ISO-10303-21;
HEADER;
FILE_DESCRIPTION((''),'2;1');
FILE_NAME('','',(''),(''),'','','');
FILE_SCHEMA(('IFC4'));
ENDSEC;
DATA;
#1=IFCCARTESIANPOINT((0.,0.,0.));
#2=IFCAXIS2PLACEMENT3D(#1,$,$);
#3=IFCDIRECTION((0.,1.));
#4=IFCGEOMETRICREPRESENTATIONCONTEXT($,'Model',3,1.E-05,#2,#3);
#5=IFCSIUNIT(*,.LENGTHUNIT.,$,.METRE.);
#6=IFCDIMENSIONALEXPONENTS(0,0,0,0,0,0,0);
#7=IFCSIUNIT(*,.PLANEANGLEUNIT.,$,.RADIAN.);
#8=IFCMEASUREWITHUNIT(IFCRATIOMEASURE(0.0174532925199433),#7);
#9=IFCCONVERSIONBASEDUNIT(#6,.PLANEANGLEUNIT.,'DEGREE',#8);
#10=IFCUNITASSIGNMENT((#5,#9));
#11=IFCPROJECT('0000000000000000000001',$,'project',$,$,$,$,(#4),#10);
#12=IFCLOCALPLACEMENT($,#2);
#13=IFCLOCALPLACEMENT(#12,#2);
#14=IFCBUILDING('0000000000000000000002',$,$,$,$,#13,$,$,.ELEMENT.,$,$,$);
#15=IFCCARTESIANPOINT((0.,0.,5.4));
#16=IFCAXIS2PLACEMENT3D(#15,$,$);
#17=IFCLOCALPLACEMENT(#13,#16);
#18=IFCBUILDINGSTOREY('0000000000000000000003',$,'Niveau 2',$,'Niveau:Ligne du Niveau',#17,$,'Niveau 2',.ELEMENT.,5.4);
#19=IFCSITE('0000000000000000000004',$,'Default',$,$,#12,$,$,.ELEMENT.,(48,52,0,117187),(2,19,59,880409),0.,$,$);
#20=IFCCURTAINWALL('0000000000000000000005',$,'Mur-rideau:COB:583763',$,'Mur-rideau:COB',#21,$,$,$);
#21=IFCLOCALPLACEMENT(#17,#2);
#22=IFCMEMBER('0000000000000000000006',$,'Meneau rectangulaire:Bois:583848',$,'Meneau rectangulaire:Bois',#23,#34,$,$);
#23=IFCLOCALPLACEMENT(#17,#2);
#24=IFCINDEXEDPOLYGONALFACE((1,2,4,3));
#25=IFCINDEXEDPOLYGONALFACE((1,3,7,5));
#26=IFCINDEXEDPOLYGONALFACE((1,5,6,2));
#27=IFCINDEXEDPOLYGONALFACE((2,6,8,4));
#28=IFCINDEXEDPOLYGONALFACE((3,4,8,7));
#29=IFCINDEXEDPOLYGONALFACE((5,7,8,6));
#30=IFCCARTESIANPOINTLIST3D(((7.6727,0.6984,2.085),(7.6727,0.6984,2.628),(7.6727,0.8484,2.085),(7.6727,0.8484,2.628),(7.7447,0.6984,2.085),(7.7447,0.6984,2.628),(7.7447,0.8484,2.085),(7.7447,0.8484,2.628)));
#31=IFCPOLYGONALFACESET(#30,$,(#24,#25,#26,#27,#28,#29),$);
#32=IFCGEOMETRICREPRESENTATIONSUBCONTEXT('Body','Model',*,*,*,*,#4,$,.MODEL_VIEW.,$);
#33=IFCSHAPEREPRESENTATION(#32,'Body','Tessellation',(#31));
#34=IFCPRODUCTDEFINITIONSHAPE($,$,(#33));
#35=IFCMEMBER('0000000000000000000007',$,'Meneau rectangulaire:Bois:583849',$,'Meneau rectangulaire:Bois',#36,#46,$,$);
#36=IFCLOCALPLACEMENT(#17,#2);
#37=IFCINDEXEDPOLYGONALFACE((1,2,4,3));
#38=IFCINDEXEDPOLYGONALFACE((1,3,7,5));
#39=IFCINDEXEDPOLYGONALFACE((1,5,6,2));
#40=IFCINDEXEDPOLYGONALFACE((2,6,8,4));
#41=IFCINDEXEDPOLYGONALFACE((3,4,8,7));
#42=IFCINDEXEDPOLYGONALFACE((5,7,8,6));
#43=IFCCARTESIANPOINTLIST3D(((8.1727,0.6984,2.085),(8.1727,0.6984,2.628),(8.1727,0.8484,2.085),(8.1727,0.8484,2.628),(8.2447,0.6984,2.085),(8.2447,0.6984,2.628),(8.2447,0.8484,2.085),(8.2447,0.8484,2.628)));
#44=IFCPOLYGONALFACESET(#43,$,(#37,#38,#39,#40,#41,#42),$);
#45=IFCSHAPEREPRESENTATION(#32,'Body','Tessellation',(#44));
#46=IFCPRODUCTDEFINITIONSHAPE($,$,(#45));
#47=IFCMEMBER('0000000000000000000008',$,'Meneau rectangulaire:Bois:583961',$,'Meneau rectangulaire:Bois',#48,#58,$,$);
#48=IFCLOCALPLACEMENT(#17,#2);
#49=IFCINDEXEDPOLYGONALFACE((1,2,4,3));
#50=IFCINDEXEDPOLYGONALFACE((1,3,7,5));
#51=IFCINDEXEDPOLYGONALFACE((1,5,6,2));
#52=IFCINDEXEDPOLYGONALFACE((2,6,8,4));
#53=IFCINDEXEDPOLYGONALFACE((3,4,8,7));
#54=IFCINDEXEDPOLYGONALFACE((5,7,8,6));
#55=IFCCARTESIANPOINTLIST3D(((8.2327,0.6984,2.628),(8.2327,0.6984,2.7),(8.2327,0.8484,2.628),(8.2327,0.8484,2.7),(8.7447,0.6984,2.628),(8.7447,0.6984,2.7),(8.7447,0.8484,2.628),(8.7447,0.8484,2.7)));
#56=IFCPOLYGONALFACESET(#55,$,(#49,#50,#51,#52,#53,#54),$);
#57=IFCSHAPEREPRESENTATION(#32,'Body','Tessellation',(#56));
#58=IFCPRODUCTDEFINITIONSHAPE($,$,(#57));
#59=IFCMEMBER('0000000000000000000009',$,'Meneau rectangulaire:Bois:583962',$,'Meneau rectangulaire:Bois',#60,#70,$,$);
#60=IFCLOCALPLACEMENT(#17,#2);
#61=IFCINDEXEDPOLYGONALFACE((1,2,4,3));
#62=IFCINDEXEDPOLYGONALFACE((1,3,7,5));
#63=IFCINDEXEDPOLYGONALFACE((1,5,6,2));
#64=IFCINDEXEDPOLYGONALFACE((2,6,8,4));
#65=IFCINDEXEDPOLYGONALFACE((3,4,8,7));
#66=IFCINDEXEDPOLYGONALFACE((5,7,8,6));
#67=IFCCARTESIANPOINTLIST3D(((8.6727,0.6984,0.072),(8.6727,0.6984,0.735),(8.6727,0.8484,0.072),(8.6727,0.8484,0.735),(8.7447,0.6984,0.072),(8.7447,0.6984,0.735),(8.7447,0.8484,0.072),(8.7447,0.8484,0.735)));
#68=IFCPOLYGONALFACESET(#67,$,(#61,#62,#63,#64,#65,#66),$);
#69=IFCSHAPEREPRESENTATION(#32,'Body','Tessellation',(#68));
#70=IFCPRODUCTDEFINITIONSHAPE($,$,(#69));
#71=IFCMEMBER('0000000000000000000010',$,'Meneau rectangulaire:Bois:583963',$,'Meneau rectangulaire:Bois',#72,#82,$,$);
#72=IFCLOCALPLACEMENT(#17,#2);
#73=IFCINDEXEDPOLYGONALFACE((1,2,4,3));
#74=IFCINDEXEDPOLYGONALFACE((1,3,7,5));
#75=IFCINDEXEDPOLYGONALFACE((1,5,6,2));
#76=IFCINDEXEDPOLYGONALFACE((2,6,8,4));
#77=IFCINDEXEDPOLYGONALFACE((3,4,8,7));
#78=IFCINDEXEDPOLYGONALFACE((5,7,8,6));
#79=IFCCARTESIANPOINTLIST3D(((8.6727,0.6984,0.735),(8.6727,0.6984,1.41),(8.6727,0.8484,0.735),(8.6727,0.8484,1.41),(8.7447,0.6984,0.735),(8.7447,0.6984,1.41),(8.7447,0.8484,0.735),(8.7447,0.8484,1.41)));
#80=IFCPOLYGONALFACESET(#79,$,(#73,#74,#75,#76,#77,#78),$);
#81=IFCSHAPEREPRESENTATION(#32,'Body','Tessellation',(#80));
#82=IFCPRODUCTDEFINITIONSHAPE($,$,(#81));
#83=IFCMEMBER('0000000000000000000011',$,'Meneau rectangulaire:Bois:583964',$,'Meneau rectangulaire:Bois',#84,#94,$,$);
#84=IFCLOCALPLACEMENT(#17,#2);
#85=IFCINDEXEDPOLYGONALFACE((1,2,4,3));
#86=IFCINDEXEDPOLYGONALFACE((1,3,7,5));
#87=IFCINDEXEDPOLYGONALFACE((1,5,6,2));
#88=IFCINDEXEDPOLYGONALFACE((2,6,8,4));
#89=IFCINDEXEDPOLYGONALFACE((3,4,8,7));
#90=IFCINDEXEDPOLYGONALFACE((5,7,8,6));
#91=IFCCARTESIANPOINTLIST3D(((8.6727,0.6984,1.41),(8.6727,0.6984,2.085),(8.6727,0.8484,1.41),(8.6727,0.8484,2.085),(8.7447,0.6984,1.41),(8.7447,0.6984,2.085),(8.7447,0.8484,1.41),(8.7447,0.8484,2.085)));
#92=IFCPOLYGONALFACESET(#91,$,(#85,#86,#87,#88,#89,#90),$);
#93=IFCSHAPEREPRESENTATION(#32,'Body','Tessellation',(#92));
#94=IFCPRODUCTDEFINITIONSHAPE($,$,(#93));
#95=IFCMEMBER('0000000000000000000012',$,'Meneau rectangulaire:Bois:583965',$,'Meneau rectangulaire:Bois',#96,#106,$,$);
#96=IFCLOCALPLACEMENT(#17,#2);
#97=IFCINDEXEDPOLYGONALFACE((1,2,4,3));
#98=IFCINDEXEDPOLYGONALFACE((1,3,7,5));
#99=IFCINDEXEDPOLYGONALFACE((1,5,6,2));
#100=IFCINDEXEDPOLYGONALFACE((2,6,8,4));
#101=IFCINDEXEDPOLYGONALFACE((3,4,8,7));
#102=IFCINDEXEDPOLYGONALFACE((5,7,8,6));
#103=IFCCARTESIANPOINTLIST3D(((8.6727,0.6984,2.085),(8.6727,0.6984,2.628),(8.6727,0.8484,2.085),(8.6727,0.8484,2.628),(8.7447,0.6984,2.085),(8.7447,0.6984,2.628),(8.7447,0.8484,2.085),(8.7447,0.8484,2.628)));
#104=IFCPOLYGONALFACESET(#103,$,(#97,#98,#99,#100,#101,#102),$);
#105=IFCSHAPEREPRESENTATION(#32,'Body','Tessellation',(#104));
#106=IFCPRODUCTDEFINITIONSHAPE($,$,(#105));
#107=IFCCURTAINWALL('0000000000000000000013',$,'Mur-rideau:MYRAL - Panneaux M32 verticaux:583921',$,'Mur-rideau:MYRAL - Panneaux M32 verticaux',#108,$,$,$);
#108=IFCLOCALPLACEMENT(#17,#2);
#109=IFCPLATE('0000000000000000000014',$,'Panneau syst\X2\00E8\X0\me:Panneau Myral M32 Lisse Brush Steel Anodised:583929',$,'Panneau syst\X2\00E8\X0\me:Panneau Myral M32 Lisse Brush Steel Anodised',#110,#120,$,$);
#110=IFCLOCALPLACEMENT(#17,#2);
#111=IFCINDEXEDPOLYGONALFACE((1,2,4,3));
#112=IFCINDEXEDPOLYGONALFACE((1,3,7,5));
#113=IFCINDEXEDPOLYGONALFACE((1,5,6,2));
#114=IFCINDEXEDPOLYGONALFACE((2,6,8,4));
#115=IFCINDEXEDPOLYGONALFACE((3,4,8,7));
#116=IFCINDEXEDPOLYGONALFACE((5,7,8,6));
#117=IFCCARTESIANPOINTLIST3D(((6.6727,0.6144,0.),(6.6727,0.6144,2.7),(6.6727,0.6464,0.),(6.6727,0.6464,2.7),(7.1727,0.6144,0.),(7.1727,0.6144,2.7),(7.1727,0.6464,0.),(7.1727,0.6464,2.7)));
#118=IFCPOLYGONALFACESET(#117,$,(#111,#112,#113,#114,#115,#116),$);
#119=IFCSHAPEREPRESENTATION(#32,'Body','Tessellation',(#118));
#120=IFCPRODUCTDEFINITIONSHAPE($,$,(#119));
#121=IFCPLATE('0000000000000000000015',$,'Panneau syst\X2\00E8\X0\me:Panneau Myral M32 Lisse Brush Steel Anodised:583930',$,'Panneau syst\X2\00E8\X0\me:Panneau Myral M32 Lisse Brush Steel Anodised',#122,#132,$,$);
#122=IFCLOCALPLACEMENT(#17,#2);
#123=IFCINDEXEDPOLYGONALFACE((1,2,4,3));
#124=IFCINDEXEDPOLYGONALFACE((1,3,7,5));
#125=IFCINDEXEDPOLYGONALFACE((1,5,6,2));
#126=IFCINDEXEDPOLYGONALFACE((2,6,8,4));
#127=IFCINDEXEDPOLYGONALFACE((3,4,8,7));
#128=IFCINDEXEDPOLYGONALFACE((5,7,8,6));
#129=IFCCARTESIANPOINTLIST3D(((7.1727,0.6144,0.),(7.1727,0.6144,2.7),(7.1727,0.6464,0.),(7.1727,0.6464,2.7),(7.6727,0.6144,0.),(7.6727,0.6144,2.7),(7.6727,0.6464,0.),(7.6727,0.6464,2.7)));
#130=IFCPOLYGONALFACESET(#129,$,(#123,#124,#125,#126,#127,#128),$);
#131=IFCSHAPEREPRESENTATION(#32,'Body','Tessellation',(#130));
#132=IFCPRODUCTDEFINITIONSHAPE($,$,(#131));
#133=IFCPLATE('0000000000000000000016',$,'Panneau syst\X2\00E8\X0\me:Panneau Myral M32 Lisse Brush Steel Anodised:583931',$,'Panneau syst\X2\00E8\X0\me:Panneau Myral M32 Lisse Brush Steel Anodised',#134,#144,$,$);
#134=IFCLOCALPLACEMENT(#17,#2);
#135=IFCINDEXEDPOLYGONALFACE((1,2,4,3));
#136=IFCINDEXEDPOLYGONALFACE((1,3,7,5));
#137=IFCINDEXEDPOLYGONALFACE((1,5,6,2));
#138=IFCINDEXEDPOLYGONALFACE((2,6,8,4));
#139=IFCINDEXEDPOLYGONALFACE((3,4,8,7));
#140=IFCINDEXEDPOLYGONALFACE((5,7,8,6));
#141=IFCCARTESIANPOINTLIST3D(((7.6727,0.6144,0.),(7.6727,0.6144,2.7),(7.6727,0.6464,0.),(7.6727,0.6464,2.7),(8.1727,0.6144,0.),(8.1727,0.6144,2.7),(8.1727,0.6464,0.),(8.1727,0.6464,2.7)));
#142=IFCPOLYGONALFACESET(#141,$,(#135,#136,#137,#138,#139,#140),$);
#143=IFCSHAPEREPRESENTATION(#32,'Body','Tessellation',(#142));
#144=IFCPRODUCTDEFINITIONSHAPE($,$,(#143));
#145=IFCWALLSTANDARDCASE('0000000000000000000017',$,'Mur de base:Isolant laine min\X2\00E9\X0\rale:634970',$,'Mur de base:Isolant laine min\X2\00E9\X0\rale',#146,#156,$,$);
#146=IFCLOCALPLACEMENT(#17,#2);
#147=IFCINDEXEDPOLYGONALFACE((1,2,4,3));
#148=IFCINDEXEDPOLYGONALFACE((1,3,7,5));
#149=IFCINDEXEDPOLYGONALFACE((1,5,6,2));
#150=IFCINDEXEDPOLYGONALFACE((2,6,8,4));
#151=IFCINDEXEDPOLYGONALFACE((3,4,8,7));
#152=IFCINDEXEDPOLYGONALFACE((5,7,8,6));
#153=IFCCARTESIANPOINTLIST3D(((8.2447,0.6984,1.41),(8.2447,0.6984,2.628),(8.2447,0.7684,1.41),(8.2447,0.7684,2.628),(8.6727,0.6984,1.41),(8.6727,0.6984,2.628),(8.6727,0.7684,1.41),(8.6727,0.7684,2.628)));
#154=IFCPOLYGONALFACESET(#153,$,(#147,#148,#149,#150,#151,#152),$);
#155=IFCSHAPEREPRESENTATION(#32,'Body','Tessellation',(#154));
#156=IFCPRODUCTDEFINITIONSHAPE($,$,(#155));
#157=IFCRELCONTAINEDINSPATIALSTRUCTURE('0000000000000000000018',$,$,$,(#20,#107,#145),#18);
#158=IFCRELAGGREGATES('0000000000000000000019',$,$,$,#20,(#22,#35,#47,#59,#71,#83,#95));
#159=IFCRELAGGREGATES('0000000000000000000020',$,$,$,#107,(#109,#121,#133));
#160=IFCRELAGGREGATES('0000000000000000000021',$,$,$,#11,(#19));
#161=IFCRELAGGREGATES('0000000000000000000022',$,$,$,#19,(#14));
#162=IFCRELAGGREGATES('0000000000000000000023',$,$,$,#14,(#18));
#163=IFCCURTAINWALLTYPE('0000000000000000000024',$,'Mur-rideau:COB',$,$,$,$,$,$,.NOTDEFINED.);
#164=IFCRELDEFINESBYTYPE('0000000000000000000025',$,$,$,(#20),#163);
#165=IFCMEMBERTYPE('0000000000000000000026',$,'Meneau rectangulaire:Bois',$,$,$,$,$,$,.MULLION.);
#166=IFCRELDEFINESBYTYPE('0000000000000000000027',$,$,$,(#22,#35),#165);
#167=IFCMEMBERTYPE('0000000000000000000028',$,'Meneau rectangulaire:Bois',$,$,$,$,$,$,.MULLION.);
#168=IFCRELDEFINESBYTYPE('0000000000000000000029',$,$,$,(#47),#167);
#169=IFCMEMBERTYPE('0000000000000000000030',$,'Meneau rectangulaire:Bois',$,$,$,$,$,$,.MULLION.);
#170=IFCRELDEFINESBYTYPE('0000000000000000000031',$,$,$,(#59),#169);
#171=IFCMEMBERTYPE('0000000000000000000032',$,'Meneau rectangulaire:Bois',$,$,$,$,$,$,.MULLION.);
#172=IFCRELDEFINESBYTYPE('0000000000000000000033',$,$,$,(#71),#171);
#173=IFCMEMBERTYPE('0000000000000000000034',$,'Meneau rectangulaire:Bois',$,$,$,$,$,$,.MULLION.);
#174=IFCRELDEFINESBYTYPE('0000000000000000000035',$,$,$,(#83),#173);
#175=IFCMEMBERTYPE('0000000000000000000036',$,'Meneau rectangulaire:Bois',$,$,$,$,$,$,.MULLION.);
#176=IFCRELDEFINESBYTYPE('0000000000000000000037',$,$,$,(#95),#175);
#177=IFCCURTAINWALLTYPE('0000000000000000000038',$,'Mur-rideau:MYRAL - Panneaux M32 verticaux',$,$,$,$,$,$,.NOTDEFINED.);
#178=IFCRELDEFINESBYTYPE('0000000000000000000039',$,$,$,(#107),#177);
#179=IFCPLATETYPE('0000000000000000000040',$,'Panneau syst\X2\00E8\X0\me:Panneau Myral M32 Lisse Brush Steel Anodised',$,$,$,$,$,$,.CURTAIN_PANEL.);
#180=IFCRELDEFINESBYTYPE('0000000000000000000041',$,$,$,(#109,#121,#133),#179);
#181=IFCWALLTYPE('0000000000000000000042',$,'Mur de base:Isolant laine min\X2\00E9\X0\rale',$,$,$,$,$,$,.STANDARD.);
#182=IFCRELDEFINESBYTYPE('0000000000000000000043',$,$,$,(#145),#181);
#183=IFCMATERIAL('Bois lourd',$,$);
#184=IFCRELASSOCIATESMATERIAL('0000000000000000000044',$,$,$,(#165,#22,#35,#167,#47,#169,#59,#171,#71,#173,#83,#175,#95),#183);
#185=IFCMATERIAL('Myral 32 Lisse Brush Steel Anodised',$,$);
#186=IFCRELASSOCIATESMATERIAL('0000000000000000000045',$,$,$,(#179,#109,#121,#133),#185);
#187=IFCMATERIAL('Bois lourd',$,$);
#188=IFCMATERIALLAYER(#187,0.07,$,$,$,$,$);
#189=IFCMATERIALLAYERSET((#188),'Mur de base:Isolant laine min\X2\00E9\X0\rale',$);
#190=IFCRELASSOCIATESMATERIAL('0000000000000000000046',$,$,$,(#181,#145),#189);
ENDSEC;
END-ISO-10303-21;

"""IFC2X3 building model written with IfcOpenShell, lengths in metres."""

from ifc_helpers import new_model, entity, si_unit, converted_unit, direction, frame, frame_2d, origin, origin_2d_with_axis, place, context, subcontext, project, spatial, rectangle, extrude, source, transform, mapped, material, layer, layer_set, layer_usage, type_object, type_shapes, element, aggregate, save


model = new_model("IFC2X3")

# Units and contexts
model_context = context("Model", 3, precision=1e-05, world=origin(), true_north=direction((0.0, 1.0)))
body_context = subcontext(model_context, "Body", "Model", "MODEL_VIEW")
ifc_project = project(units=[si_unit("LENGTHUNIT", "METRE"), converted_unit("PLANEANGLEUNIT", "DEGREE", entity("IfcRatioMeasure", 0.0174532925199433), si_unit("PLANEANGLEUNIT", "RADIAN"), dimensions=[0, 0, 0, 0, 0, 0, 0])], contexts=[model_context])

# Site, building, storey
site_placement = place(None, origin())
site = spatial("IfcSite", under=ifc_project, at=site_placement, Name="Default", CompositionType="ELEMENT", RefLatitude=(48, 52, 0, 117187), RefLongitude=(2, 19, 59, 880409), RefElevation=0.0)
building_placement = place(site_placement, origin())
building = spatial("IfcBuilding", under=site, at=building_placement, CompositionType="ELEMENT")
storey_placement = place(building_placement, frame((0.0, 0.0, 5.4)))
storey = spatial("IfcBuildingStorey", under=building, at=storey_placement, Name="Niveau 2", ObjectType="Niveau:Ligne du Niveau", LongName="Niveau 2", CompositionType="ELEMENT", Elevation=5.4)

# Curtain wall, members
curtain_wall_type_1 = type_object("IfcCurtainWallType", Name="Mur-rideau:COB", PredefinedType="NOTDEFINED")
curtain_wall_1_placement = place(storey_placement, frame((0.0, 0.0, -5.4)))
curtain_wall_1 = element("IfcCurtainWall", 1, at=curtain_wall_1_placement, inside=storey, type_object=curtain_wall_type_1, Name="Mur-rideau:COB:583763", ObjectType="Mur-rideau:COB")
ifc_material_1 = material(Name="Bois lourd")
member_type_1 = type_object("IfcMemberType", Name="Meneau rectangulaire:Bois", PredefinedType="MULLION", material=ifc_material_1)
shared_shape_1 = source(origin(), body_context, "Body", "SweptSolid", [
    extrude(rectangle(XDim=0.15, YDim=0.072, at=origin_2d_with_axis()), frame((-0.024, 0.0, -0.543), z_axis=(0.0, 0.0, 1.0), x_axis=(0.0, -1.0, 0.0)), (0.0, 0.0, 1.0), 0.543),
])
type_shapes(member_type_1, [shared_shape_1])
member_1_placement = place(storey_placement, frame((7.7327, 0.7734, 2.085), z_axis=(0.0, 0.0, -1.0), x_axis=(1.0, 0.0, 0.0)))
member_1 = element("IfcMember", 2, at=member_1_placement, type_object=member_type_1, material=ifc_material_1, Name="Meneau rectangulaire:Bois:583848", ObjectType="Meneau rectangulaire:Bois", context=body_context, shape_type="MappedRepresentation", body=[
    mapped(shared_shape_1, transform((0.0, 0.0, 0.0), scale=1.0)),
])
member_2_placement = place(storey_placement, frame((8.2327, 0.7734, 2.085), z_axis=(0.0, 0.0, -1.0), x_axis=(1.0, 0.0, 0.0)))
member_2 = element("IfcMember", 3, at=member_2_placement, type_object=member_type_1, material=ifc_material_1, Name="Meneau rectangulaire:Bois:583849", ObjectType="Meneau rectangulaire:Bois", context=body_context, shape_type="MappedRepresentation", body=[
    mapped(shared_shape_1, transform((0.0, 0.0, 0.0), scale=1.0)),
])
member_type_2 = type_object("IfcMemberType", Name="Meneau rectangulaire:Bois", PredefinedType="MULLION", material=ifc_material_1)
shared_shape_2 = source(origin(), body_context, "Body", "SweptSolid", [
    extrude(rectangle(XDim=0.15, YDim=0.072, at=origin_2d_with_axis()), frame((-0.036, 0.0, -0.512), z_axis=(0.0, 0.0, 1.0), x_axis=(0.0, -1.0, 0.0)), (0.0, 0.0, 1.0), 0.512),
])
type_shapes(member_type_2, [shared_shape_2])
member_3_placement = place(storey_placement, frame((8.7447, 0.7734, 2.7), z_axis=(1.0, 0.0, 0.0), x_axis=(0.0, 0.0, 1.0)))
member_3 = element("IfcMember", 4, at=member_3_placement, type_object=member_type_2, material=ifc_material_1, Name="Meneau rectangulaire:Bois:583961", ObjectType="Meneau rectangulaire:Bois", context=body_context, shape_type="MappedRepresentation", body=[
    mapped(shared_shape_2, transform((0.0, 0.0, 0.0), scale=1.0)),
])
member_type_3 = type_object("IfcMemberType", Name="Meneau rectangulaire:Bois", PredefinedType="MULLION", material=ifc_material_1)
shared_shape_3 = source(origin(), body_context, "Body", "SweptSolid", [
    extrude(rectangle(XDim=0.15, YDim=0.072, at=origin_2d_with_axis()), frame((-0.024, 0.0, -0.663), z_axis=(0.0, 0.0, 1.0), x_axis=(0.0, -1.0, 0.0)), (0.0, 0.0, 1.0), 0.663),
])
type_shapes(member_type_3, [shared_shape_3])
member_4_placement = place(storey_placement, frame((8.7327, 0.7734, 0.072), z_axis=(0.0, 0.0, -1.0), x_axis=(1.0, 0.0, 0.0)))
member_4 = element("IfcMember", 5, at=member_4_placement, type_object=member_type_3, material=ifc_material_1, Name="Meneau rectangulaire:Bois:583962", ObjectType="Meneau rectangulaire:Bois", context=body_context, shape_type="MappedRepresentation", body=[
    mapped(shared_shape_3, transform((0.0, 0.0, 0.0), scale=1.0)),
])
member_type_4 = type_object("IfcMemberType", Name="Meneau rectangulaire:Bois", PredefinedType="MULLION", material=ifc_material_1)
shared_shape_4 = source(origin(), body_context, "Body", "SweptSolid", [
    extrude(rectangle(XDim=0.15, YDim=0.072, at=origin_2d_with_axis()), frame((-0.024, 0.0, -0.675), z_axis=(0.0, 0.0, 1.0), x_axis=(0.0, -1.0, 0.0)), (0.0, 0.0, 1.0), 0.675),
])
type_shapes(member_type_4, [shared_shape_4])
member_5_placement = place(storey_placement, frame((8.7327, 0.7734, 0.735), z_axis=(0.0, 0.0, -1.0), x_axis=(1.0, 0.0, 0.0)))
member_5 = element("IfcMember", 6, at=member_5_placement, type_object=member_type_4, material=ifc_material_1, Name="Meneau rectangulaire:Bois:583963", ObjectType="Meneau rectangulaire:Bois", context=body_context, shape_type="MappedRepresentation", body=[
    mapped(shared_shape_4, transform((0.0, 0.0, 0.0), scale=1.0)),
])
member_type_5 = type_object("IfcMemberType", Name="Meneau rectangulaire:Bois", PredefinedType="MULLION", material=ifc_material_1)
shared_shape_5 = source(origin(), body_context, "Body", "SweptSolid", [
    extrude(rectangle(XDim=0.15, YDim=0.072, at=origin_2d_with_axis()), frame((-0.024, 0.0, -0.675), z_axis=(0.0, 0.0, 1.0), x_axis=(0.0, -1.0, 0.0)), (0.0, 0.0, 1.0), 0.675),
])
type_shapes(member_type_5, [shared_shape_5])
member_6_placement = place(storey_placement, frame((8.7327, 0.7734, 1.41), z_axis=(0.0, 0.0, -1.0), x_axis=(1.0, 0.0, 0.0)))
member_6 = element("IfcMember", 7, at=member_6_placement, type_object=member_type_5, material=ifc_material_1, Name="Meneau rectangulaire:Bois:583964", ObjectType="Meneau rectangulaire:Bois", context=body_context, shape_type="MappedRepresentation", body=[
    mapped(shared_shape_5, transform((0.0, 0.0, 0.0), scale=1.0)),
])
member_type_6 = type_object("IfcMemberType", Name="Meneau rectangulaire:Bois", PredefinedType="MULLION", material=ifc_material_1)
shared_shape_6 = source(origin(), body_context, "Body", "SweptSolid", [
    extrude(rectangle(XDim=0.15, YDim=0.072, at=origin_2d_with_axis()), frame((-0.024, 0.0, -0.543), z_axis=(0.0, 0.0, 1.0), x_axis=(0.0, -1.0, 0.0)), (0.0, 0.0, 1.0), 0.543),
])
type_shapes(member_type_6, [shared_shape_6])
member_7_placement = place(storey_placement, frame((8.7327, 0.7734, 2.085), z_axis=(0.0, 0.0, -1.0), x_axis=(1.0, 0.0, 0.0)))
member_7 = element("IfcMember", 8, at=member_7_placement, type_object=member_type_6, material=ifc_material_1, Name="Meneau rectangulaire:Bois:583965", ObjectType="Meneau rectangulaire:Bois", context=body_context, shape_type="MappedRepresentation", body=[
    mapped(shared_shape_6, transform((0.0, 0.0, 0.0), scale=1.0)),
])
aggregate(curtain_wall_1, [member_1, member_2, member_3, member_4, member_5, member_6, member_7])

# Curtain wall, plates
curtain_wall_type_2 = type_object("IfcCurtainWallType", Name="Mur-rideau:MYRAL - Panneaux M32 verticaux", PredefinedType="NOTDEFINED")
curtain_wall_2_placement = place(storey_placement, frame((0.0, 0.0, -5.4)))
curtain_wall_2 = element("IfcCurtainWall", 9, at=curtain_wall_2_placement, inside=storey, type_object=curtain_wall_type_2, Name="Mur-rideau:MYRAL - Panneaux M32 verticaux:583921", ObjectType="Mur-rideau:MYRAL - Panneaux M32 verticaux")
ifc_material_2 = material(Name="Myral 32 Lisse Brush Steel Anodised")
plate_type = type_object("IfcPlateType", Name="Panneau système:Panneau Myral M32 Lisse Brush Steel Anodised", PredefinedType="CURTAIN_PANEL", material=ifc_material_2)
shared_shape_7 = source(origin(), body_context, "Body", "SweptSolid", [
    extrude(rectangle(XDim=0.032, YDim=0.5, at=origin_2d_with_axis()), frame((0.0, -0.016, 0.0), z_axis=(0.0, 0.0, 1.0), x_axis=(0.0, 1.0, 0.0)), (0.0, 0.0, 1.0), 2.7),
])
type_shapes(plate_type, [shared_shape_7])
plate_1_placement = place(curtain_wall_2_placement, frame((6.9227, 0.6464, 5.4)))
plate_1 = element("IfcPlate", 10, at=plate_1_placement, type_object=plate_type, material=ifc_material_2, Name="Panneau système:Panneau Myral M32 Lisse Brush Steel Anodised:583929", ObjectType="Panneau système:Panneau Myral M32 Lisse Brush Steel Anodised", context=body_context, shape_type="MappedRepresentation", body=[
    mapped(shared_shape_7, transform((0.0, 0.0, 0.0), scale=1.0)),
])
plate_2_placement = place(curtain_wall_2_placement, frame((7.4227, 0.6464, 5.4)))
plate_2 = element("IfcPlate", 11, at=plate_2_placement, type_object=plate_type, material=ifc_material_2, Name="Panneau système:Panneau Myral M32 Lisse Brush Steel Anodised:583930", ObjectType="Panneau système:Panneau Myral M32 Lisse Brush Steel Anodised", context=body_context, shape_type="MappedRepresentation", body=[
    mapped(shared_shape_7, transform((0.0, 0.0, 0.0), scale=1.0)),
])
plate_3_placement = place(curtain_wall_2_placement, frame((7.9227, 0.6464, 5.4)))
plate_3 = element("IfcPlate", 12, at=plate_3_placement, type_object=plate_type, material=ifc_material_2, Name="Panneau système:Panneau Myral M32 Lisse Brush Steel Anodised:583931", ObjectType="Panneau système:Panneau Myral M32 Lisse Brush Steel Anodised", context=body_context, shape_type="MappedRepresentation", body=[
    mapped(shared_shape_7, transform((0.0, 0.0, 0.0), scale=1.0)),
])
aggregate(curtain_wall_2, [plate_1, plate_2, plate_3])

# Wall
ifc_material_3 = material(Name="Bois lourd")
ifc_layer = layer(ifc_material_3, 0.07)
ifc_layer_set = layer_set([ifc_layer], Name="Mur de base:Isolant laine minérale")
ifc_layer_usage = layer_usage(ifc_layer_set, "AXIS2", "NEGATIVE", 0.035)
wall_type = type_object("IfcWallType", Name="Mur de base:Isolant laine minérale", PredefinedType="STANDARD", material=ifc_layer_set)
wall_placement = place(storey_placement, frame((8.2447, 0.7334, 1.41)))
element("IfcWallStandardCase", 13, at=wall_placement, inside=storey, type_object=wall_type, material=ifc_layer_usage, Name="Mur de base:Isolant laine minérale:634970", ObjectType="Mur de base:Isolant laine minérale", context=body_context, shape_type="SweptSolid", body=[
    extrude(rectangle(XDim=0.428, YDim=0.07, at=frame_2d((0.214, 0.0), x_axis=(-1.0, 0.0))), origin(), (0.0, 0.0, 1.0), 1.218),
])

save(model, "model.ifc")
